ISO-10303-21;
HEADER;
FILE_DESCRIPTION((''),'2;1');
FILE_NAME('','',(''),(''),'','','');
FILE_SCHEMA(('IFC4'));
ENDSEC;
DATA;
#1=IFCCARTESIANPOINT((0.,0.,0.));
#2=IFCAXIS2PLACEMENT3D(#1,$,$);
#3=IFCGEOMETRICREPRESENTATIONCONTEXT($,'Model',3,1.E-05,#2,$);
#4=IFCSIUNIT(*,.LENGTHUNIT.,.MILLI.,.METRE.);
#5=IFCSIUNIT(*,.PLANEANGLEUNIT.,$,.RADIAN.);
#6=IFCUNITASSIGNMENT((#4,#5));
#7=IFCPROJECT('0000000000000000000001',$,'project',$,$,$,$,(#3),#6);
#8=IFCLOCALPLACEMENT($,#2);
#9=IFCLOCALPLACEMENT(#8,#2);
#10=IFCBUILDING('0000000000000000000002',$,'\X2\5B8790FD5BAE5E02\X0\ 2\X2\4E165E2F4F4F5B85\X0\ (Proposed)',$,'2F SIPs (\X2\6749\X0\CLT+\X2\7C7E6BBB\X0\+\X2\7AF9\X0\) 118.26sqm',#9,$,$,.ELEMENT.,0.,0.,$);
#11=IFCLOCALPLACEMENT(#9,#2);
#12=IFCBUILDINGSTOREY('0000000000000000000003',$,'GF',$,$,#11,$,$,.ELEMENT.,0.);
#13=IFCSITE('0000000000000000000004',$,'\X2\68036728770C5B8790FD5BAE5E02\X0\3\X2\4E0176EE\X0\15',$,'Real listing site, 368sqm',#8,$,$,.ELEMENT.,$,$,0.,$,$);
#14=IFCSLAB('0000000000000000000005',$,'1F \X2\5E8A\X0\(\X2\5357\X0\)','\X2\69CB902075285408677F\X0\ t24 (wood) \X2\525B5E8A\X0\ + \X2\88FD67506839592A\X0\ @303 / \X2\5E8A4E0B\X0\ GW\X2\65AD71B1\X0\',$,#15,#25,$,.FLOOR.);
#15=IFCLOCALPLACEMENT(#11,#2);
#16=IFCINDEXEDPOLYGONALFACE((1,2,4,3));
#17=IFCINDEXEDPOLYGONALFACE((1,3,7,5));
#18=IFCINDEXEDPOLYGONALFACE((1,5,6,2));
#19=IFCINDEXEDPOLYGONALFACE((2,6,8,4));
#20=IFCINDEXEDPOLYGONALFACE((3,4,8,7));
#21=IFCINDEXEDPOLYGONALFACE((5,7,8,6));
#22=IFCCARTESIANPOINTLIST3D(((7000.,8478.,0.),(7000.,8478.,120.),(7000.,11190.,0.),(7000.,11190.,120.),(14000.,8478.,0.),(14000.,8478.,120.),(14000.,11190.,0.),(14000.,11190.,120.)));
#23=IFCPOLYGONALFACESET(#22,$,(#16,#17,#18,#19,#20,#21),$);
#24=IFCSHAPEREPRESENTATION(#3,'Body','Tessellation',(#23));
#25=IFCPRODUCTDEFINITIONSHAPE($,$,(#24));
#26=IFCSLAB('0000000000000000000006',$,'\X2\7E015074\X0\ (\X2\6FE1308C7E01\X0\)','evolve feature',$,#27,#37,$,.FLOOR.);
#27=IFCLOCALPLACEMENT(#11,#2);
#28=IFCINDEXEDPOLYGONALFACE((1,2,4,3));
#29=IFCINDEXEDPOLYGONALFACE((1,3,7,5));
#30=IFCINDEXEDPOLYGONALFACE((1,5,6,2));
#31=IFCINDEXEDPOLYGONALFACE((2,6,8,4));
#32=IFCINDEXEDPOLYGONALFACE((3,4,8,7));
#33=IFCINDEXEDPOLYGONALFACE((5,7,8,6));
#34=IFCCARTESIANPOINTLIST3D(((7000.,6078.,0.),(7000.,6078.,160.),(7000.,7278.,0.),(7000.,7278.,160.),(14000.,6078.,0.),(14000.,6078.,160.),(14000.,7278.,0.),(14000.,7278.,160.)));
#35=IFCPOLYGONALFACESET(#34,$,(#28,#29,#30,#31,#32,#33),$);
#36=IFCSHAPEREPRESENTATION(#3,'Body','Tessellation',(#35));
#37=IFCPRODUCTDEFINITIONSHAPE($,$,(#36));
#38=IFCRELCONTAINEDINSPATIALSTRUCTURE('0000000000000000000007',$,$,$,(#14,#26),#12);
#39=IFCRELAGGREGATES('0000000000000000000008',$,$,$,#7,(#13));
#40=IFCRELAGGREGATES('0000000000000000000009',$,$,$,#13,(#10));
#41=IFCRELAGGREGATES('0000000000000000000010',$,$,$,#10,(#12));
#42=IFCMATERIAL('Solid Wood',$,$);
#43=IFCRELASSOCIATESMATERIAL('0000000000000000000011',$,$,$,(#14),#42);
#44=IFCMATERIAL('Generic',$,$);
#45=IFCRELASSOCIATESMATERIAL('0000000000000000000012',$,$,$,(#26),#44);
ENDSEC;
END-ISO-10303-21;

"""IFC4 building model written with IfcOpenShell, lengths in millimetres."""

from ifc_helpers import new_model, si_unit, frame, frame_2d, origin, place, context, project, spatial, rectangle, extrude, material, element, save


model = new_model("IFC4")

# Units and contexts
model_context = context("Model", 3, precision=1e-05, world=origin())
ifc_project = project(units=[si_unit("LENGTHUNIT", "METRE", prefix="MILLI"), si_unit("PLANEANGLEUNIT", "RADIAN")], contexts=[model_context])

# Site, building, storey
site_placement = place(None, origin())
site = spatial("IfcSite", under=ifc_project, at=site_placement, Name="栃木県宇都宮市3丁目15", ObjectType="Real listing site, 368sqm", CompositionType="ELEMENT", RefElevation=0.0)
building_placement = place(site_placement, origin())
building = spatial("IfcBuilding", under=site, at=building_placement, Name="宇都宮市 2世帯住宅 (Proposed)", ObjectType="2F SIPs (杉CLT+籾殻+竹) 118.26sqm", CompositionType="ELEMENT", ElevationOfRefHeight=0.0, ElevationOfTerrain=0.0)
storey_placement = place(building_placement, origin())
storey = spatial("IfcBuildingStorey", under=building, at=storey_placement, Name="GF", CompositionType="ELEMENT", Elevation=0.0)

# Slabs
ifc_material_1 = material(Name="Solid Wood")
slab_1_placement = place(storey_placement, frame((3500.0, 4239.0, 0.0)))
element("IfcSlab", 1, at=slab_1_placement, inside=storey, material=ifc_material_1, Name="1F 床(南)", Description="構造用合板 t24 (wood) 剛床 + 製材根太 @303 / 床下 GW断熱", PredefinedType="FLOOR", context=model_context, shape_type="SweptSolid", body=[
    extrude(rectangle(XDim=7000.0, YDim=2712.0, at=frame_2d((3500.0, 1356.0))), frame((3500.0, 4239.0, 0.0)), (0.0, 0.0, 1.0), 120.0),
])
ifc_material_2 = material(Name="Generic")
slab_2_placement = place(storey_placement, frame((3500.0, 3039.0, 0.0)))
element("IfcSlab", 2, at=slab_2_placement, inside=storey, material=ifc_material_2, Name="縁側 (濡れ縁)", Description="evolve feature", PredefinedType="FLOOR", context=model_context, shape_type="SweptSolid", body=[
    extrude(rectangle(XDim=7000.0, YDim=1200.0, at=frame_2d((3500.0, 600.0))), frame((3500.0, 3039.0, 0.0)), (0.0, 0.0, 1.0), 160.0),
])

save(model, "model.ifc")
